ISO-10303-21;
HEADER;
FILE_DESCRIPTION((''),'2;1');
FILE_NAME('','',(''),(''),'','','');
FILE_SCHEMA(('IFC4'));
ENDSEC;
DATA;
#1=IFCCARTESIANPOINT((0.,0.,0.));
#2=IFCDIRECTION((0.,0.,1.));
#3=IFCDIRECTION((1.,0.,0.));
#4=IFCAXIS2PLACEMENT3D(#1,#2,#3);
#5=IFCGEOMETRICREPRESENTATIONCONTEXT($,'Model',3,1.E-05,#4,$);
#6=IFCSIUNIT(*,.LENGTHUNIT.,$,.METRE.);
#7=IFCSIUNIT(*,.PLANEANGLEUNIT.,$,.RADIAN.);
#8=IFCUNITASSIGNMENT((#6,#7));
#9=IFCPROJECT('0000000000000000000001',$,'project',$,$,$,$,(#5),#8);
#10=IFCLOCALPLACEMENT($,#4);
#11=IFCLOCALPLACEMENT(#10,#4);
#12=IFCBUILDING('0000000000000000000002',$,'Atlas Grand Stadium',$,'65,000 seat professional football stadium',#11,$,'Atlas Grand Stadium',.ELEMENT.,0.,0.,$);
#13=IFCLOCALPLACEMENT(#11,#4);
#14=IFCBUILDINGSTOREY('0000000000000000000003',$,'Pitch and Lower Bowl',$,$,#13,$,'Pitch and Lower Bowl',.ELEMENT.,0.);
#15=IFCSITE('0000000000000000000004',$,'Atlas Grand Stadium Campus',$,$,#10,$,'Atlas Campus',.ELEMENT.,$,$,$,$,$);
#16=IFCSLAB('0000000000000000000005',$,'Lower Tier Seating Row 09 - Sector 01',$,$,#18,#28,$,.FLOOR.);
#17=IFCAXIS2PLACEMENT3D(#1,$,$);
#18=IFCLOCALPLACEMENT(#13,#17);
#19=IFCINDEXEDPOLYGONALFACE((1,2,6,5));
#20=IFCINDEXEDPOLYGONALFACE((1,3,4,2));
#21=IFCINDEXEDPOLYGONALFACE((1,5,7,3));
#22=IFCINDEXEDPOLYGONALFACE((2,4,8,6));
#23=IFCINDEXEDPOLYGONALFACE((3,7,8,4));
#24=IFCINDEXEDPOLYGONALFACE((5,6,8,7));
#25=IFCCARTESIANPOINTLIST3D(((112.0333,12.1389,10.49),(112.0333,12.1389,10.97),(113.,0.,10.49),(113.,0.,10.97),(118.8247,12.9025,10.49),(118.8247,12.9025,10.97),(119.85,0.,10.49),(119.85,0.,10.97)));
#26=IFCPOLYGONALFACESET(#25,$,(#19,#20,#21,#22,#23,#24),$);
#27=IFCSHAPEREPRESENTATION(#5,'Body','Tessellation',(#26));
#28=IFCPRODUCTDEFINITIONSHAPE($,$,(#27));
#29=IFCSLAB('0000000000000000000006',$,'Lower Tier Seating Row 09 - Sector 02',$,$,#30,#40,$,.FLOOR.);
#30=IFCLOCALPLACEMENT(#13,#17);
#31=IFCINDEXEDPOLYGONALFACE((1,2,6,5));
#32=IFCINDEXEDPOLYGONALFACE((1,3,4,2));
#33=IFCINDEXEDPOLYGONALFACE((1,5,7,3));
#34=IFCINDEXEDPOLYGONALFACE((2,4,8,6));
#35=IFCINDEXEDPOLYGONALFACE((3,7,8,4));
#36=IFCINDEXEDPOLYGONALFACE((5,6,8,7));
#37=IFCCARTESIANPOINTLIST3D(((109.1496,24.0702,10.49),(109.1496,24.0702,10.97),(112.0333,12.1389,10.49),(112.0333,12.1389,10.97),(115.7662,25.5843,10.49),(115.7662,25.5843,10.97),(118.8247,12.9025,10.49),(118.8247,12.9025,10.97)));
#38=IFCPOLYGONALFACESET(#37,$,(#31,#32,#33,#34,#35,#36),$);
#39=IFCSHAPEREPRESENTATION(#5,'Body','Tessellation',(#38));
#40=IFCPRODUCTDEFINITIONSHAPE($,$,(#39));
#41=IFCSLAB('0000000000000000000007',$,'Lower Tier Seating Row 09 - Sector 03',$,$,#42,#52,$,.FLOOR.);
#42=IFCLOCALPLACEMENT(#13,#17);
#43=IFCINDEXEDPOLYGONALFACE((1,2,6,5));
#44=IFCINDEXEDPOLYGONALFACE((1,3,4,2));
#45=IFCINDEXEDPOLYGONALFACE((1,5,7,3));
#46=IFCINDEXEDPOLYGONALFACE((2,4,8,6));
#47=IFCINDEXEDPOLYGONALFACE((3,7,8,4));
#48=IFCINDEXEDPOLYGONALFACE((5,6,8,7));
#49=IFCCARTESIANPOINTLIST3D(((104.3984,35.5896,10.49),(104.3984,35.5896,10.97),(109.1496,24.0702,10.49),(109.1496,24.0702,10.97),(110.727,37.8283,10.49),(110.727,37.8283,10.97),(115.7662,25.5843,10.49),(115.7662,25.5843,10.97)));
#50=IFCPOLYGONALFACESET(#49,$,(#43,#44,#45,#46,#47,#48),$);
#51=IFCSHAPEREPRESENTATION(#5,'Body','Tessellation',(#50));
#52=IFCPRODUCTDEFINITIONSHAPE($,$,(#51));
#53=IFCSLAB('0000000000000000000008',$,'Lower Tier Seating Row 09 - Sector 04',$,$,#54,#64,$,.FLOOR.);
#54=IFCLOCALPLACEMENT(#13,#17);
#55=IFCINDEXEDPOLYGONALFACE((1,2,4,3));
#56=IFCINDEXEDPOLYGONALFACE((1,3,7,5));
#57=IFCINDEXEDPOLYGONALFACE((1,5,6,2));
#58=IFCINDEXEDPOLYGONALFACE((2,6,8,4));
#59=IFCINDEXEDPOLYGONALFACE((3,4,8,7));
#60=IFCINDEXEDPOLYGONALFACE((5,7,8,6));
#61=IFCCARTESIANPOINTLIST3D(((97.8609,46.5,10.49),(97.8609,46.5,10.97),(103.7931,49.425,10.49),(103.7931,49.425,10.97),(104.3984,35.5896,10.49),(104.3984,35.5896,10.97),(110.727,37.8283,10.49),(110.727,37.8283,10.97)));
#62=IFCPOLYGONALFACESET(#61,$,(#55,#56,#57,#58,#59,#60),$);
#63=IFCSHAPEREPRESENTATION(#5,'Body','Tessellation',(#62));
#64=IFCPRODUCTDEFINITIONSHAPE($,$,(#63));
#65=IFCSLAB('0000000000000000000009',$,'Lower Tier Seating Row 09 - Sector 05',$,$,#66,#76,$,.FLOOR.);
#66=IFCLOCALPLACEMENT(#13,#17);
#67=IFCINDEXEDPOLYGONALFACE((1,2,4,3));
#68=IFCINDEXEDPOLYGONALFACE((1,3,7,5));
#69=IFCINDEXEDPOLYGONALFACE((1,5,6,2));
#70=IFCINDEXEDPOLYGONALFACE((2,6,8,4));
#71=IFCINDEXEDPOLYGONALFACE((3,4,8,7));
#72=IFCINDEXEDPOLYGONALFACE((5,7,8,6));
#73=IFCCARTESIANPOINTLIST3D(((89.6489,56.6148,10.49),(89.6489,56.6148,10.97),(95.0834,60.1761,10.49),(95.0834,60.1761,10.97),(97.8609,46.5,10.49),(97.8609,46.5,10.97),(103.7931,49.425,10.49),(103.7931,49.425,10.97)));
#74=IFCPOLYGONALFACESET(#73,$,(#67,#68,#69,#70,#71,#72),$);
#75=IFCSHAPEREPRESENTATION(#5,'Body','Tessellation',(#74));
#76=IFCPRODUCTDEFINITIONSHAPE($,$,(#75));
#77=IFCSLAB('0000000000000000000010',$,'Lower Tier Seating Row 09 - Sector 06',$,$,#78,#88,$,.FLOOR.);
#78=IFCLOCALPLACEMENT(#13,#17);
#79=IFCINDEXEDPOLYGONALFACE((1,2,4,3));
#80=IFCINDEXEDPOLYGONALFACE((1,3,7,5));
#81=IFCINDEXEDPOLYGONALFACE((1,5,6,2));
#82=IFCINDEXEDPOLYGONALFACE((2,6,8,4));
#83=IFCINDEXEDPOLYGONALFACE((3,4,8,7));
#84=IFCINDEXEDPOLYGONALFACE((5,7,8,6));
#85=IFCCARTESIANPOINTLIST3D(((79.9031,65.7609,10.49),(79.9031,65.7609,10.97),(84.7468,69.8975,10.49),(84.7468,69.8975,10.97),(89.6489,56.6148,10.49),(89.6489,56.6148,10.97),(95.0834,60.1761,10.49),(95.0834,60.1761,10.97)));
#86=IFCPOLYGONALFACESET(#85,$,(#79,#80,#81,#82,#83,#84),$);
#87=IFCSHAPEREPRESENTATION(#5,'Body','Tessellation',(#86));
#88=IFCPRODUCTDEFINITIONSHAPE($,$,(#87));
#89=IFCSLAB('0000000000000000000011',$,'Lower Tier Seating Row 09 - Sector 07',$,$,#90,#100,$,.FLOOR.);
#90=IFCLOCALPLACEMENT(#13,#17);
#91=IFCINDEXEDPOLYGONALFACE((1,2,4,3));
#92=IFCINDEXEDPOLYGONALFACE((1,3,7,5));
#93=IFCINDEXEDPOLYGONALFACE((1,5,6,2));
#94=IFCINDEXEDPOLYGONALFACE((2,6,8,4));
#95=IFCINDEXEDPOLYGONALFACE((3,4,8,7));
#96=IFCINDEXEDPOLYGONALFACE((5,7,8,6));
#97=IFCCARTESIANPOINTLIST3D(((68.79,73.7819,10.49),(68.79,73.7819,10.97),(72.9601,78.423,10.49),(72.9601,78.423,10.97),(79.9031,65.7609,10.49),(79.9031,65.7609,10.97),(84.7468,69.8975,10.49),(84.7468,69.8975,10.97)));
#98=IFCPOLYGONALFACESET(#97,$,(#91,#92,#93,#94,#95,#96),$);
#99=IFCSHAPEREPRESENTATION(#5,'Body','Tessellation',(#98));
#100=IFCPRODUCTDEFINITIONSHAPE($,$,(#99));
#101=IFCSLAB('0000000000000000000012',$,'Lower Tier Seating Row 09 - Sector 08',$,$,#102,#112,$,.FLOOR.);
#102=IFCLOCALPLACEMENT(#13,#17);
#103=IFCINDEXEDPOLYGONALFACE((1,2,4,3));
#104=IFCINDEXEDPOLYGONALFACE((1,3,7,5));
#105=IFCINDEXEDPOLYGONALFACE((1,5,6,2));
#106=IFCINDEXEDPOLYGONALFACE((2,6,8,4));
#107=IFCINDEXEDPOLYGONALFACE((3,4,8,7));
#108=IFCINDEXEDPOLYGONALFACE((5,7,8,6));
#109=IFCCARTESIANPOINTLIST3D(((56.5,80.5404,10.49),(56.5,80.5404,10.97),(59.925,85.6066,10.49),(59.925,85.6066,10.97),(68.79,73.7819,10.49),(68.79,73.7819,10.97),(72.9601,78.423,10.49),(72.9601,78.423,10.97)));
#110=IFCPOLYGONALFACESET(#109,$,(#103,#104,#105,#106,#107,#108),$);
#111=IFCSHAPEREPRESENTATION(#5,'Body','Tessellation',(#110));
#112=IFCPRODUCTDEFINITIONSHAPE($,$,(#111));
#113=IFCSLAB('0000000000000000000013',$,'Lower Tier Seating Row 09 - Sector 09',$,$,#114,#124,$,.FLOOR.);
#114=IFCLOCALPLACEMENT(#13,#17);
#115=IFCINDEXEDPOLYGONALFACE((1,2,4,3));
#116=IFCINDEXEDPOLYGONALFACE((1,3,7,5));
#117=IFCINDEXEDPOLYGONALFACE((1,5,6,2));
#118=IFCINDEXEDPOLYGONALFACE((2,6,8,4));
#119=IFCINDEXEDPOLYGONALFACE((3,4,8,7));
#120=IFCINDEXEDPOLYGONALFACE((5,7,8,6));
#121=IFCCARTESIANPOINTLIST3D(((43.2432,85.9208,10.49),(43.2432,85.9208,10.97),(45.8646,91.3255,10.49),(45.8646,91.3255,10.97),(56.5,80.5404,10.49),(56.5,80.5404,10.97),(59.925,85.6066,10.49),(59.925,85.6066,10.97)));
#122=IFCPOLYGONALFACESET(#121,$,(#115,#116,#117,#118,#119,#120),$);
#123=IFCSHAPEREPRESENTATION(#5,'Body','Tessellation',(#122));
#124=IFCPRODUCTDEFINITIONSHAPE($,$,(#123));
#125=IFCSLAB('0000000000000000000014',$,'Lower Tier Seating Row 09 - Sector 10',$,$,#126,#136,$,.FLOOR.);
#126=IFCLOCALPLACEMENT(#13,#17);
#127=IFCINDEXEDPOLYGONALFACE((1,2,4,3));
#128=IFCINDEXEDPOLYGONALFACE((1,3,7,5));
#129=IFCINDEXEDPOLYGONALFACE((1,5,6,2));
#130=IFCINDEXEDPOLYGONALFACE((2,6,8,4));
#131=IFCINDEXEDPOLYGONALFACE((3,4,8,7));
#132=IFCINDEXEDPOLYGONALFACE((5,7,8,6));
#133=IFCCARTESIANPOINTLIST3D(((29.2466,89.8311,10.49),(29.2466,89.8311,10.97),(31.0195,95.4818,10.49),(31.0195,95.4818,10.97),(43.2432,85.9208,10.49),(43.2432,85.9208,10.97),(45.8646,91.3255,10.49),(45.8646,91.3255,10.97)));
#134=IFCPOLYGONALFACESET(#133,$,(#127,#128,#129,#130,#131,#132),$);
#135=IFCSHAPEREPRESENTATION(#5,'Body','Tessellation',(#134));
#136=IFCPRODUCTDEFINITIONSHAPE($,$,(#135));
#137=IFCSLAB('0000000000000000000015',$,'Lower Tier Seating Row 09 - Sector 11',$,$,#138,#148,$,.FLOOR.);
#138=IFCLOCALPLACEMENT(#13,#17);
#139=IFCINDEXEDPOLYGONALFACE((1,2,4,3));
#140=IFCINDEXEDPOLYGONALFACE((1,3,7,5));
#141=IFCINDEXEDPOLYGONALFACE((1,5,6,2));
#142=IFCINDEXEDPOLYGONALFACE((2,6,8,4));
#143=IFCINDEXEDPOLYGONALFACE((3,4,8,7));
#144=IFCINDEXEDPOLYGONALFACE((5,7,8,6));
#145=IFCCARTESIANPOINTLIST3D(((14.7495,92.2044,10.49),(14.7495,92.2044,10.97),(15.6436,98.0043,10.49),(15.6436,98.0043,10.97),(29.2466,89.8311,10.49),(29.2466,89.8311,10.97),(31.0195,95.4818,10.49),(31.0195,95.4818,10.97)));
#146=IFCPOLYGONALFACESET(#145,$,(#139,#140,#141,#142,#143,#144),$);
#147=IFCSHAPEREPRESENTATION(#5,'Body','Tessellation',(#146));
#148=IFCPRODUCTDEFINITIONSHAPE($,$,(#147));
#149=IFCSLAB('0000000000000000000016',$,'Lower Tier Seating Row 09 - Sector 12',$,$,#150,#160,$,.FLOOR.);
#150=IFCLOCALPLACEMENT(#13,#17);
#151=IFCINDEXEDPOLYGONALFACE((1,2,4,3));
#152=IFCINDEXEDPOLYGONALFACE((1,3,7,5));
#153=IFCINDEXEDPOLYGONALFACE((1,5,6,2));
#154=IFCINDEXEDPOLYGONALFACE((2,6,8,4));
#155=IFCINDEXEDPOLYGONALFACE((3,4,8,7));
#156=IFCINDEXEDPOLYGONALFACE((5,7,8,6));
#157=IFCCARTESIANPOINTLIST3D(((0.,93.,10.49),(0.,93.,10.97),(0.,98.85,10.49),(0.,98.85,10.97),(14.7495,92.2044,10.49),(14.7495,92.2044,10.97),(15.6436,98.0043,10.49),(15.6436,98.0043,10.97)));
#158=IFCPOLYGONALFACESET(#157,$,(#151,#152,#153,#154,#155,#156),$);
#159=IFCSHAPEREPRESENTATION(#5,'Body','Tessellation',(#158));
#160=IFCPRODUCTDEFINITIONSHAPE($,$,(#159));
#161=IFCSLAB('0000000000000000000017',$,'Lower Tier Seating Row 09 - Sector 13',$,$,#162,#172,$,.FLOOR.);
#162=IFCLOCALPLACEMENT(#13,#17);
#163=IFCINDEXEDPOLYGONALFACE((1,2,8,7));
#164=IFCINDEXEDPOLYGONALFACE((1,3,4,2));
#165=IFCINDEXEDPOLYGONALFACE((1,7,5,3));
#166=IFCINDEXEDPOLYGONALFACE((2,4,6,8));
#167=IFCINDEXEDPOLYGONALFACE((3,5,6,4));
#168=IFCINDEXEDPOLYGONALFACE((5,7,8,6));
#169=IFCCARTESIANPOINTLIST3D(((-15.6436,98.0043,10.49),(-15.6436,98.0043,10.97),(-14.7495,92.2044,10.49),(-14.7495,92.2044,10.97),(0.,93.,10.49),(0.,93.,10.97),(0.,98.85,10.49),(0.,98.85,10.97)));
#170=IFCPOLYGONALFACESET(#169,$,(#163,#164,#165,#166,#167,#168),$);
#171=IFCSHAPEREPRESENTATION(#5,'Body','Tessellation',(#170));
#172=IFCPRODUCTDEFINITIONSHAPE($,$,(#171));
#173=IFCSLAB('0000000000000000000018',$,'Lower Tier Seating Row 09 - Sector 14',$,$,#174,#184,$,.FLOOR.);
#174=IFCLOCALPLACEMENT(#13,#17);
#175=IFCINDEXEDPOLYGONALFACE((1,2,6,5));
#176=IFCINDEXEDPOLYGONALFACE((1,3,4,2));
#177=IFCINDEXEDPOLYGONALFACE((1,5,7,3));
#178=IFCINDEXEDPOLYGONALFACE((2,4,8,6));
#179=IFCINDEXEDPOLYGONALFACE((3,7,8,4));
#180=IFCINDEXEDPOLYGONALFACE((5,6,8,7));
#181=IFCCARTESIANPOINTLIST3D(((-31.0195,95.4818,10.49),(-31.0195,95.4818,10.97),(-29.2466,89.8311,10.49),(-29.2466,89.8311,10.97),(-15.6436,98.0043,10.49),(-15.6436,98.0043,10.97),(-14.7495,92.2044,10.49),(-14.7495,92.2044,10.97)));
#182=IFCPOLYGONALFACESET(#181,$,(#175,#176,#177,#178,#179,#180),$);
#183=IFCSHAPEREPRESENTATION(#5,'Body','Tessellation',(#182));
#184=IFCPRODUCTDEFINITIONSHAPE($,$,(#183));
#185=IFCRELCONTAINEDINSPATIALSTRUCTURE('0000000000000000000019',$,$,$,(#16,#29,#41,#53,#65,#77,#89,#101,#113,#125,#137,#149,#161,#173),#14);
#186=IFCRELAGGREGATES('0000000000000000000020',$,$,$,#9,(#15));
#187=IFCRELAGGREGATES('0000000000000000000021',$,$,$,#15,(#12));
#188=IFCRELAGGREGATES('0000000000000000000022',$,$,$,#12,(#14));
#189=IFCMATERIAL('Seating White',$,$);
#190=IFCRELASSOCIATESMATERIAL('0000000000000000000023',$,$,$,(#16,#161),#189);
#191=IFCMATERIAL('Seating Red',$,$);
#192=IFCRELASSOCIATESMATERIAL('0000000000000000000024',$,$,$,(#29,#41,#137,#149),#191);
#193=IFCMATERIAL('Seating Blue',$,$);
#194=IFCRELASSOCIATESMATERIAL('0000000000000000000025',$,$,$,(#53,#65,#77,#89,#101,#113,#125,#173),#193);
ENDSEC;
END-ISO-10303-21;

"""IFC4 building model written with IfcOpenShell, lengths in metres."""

from ifc_helpers import new_model, si_unit, frame, origin_with_axes, place, context, project, spatial, polyline, outline, extrude, material, element, save


model = new_model("IFC4")

# Units and contexts
model_context = context("Model", 3, precision=1e-05, world=origin_with_axes())
ifc_project = project(units=[si_unit("LENGTHUNIT", "METRE"), si_unit("PLANEANGLEUNIT", "RADIAN")], contexts=[model_context])

# Site, building, storey
site_placement = place(None, origin_with_axes())
site = spatial("IfcSite", under=ifc_project, at=site_placement, Name="Atlas Grand Stadium Campus", LongName="Atlas Campus", CompositionType="ELEMENT")
building_placement = place(site_placement, origin_with_axes())
building = spatial("IfcBuilding", under=site, at=building_placement, Name="Atlas Grand Stadium", ObjectType="65,000 seat professional football stadium", LongName="Atlas Grand Stadium", CompositionType="ELEMENT", ElevationOfRefHeight=0.0, ElevationOfTerrain=0.0)
storey_placement = place(building_placement, origin_with_axes())
storey = spatial("IfcBuildingStorey", under=building, at=storey_placement, Name="Pitch and Lower Bowl", LongName="Pitch and Lower Bowl", CompositionType="ELEMENT", Elevation=0.0)

# Slabs
ifc_material_1 = material(Name="Seating White")
slab_1_placement = place(storey_placement, frame((0.0, 0.0, 10.49), z_axis=(0.0, 0.0, 1.0), x_axis=(1.0, 0.0, 0.0)))
element("IfcSlab", 1, at=slab_1_placement, inside=storey, material=ifc_material_1, Name="Lower Tier Seating Row 09 - Sector 01", PredefinedType="FLOOR", context=model_context, shape_type="SweptSolid", body=[
    extrude(outline(polyline([(119.85, 0.0), (118.8247, 12.9025), (112.0333, 12.1389), (113.0, 0.0), (119.85, 0.0)])), origin_with_axes(), (0.0, 0.0, 1.0), 0.48),
])
ifc_material_2 = material(Name="Seating Red")
slab_2_placement = place(storey_placement, frame((0.0, 0.0, 10.49), z_axis=(0.0, 0.0, 1.0), x_axis=(1.0, 0.0, 0.0)))
element("IfcSlab", 2, at=slab_2_placement, inside=storey, material=ifc_material_2, Name="Lower Tier Seating Row 09 - Sector 02", PredefinedType="FLOOR", context=model_context, shape_type="SweptSolid", body=[
    extrude(outline(polyline([(118.8247, 12.9025), (115.7662, 25.5843), (109.1496, 24.0702), (112.0333, 12.1389), (118.8247, 12.9025)])), origin_with_axes(), (0.0, 0.0, 1.0), 0.48),
])
slab_3_placement = place(storey_placement, frame((0.0, 0.0, 10.49), z_axis=(0.0, 0.0, 1.0), x_axis=(1.0, 0.0, 0.0)))
element("IfcSlab", 3, at=slab_3_placement, inside=storey, material=ifc_material_2, Name="Lower Tier Seating Row 09 - Sector 03", PredefinedType="FLOOR", context=model_context, shape_type="SweptSolid", body=[
    extrude(outline(polyline([(115.7662, 25.5843), (110.727, 37.8283), (104.3984, 35.5896), (109.1496, 24.0702), (115.7662, 25.5843)])), origin_with_axes(), (0.0, 0.0, 1.0), 0.48),
])
ifc_material_3 = material(Name="Seating Blue")
slab_4_placement = place(storey_placement, frame((0.0, 0.0, 10.49), z_axis=(0.0, 0.0, 1.0), x_axis=(1.0, 0.0, 0.0)))
element("IfcSlab", 4, at=slab_4_placement, inside=storey, material=ifc_material_3, Name="Lower Tier Seating Row 09 - Sector 04", PredefinedType="FLOOR", context=model_context, shape_type="SweptSolid", body=[
    extrude(outline(polyline([(110.727, 37.8283), (103.7931, 49.425), (97.8609, 46.5), (104.3984, 35.5896), (110.727, 37.8283)])), origin_with_axes(), (0.0, 0.0, 1.0), 0.48),
])
slab_5_placement = place(storey_placement, frame((0.0, 0.0, 10.49), z_axis=(0.0, 0.0, 1.0), x_axis=(1.0, 0.0, 0.0)))
element("IfcSlab", 5, at=slab_5_placement, inside=storey, material=ifc_material_3, Name="Lower Tier Seating Row 09 - Sector 05", PredefinedType="FLOOR", context=model_context, shape_type="SweptSolid", body=[
    extrude(outline(polyline([(103.7931, 49.425), (95.0834, 60.1761), (89.6489, 56.6148), (97.8609, 46.5), (103.7931, 49.425)])), origin_with_axes(), (0.0, 0.0, 1.0), 0.48),
])
slab_6_placement = place(storey_placement, frame((0.0, 0.0, 10.49), z_axis=(0.0, 0.0, 1.0), x_axis=(1.0, 0.0, 0.0)))
element("IfcSlab", 6, at=slab_6_placement, inside=storey, material=ifc_material_3, Name="Lower Tier Seating Row 09 - Sector 06", PredefinedType="FLOOR", context=model_context, shape_type="SweptSolid", body=[
    extrude(outline(polyline([(95.0834, 60.1761), (84.7468, 69.8975), (79.9031, 65.7609), (89.6489, 56.6148), (95.0834, 60.1761)])), origin_with_axes(), (0.0, 0.0, 1.0), 0.48),
])
slab_7_placement = place(storey_placement, frame((0.0, 0.0, 10.49), z_axis=(0.0, 0.0, 1.0), x_axis=(1.0, 0.0, 0.0)))
element("IfcSlab", 7, at=slab_7_placement, inside=storey, material=ifc_material_3, Name="Lower Tier Seating Row 09 - Sector 07", PredefinedType="FLOOR", context=model_context, shape_type="SweptSolid", body=[
    extrude(outline(polyline([(84.7468, 69.8975), (72.9601, 78.423), (68.79, 73.7819), (79.9031, 65.7609), (84.7468, 69.8975)])), origin_with_axes(), (0.0, 0.0, 1.0), 0.48),
])
slab_8_placement = place(storey_placement, frame((0.0, 0.0, 10.49), z_axis=(0.0, 0.0, 1.0), x_axis=(1.0, 0.0, 0.0)))
element("IfcSlab", 8, at=slab_8_placement, inside=storey, material=ifc_material_3, Name="Lower Tier Seating Row 09 - Sector 08", PredefinedType="FLOOR", context=model_context, shape_type="SweptSolid", body=[
    extrude(outline(polyline([(72.9601, 78.423), (59.925, 85.6066), (56.5, 80.5404), (68.79, 73.7819), (72.9601, 78.423)])), origin_with_axes(), (0.0, 0.0, 1.0), 0.48),
])
slab_9_placement = place(storey_placement, frame((0.0, 0.0, 10.49), z_axis=(0.0, 0.0, 1.0), x_axis=(1.0, 0.0, 0.0)))
element("IfcSlab", 9, at=slab_9_placement, inside=storey, material=ifc_material_3, Name="Lower Tier Seating Row 09 - Sector 09", PredefinedType="FLOOR", context=model_context, shape_type="SweptSolid", body=[
    extrude(outline(polyline([(59.925, 85.6066), (45.8646, 91.3255), (43.2432, 85.9208), (56.5, 80.5404), (59.925, 85.6066)])), origin_with_axes(), (0.0, 0.0, 1.0), 0.48),
])
slab_10_placement = place(storey_placement, frame((0.0, 0.0, 10.49), z_axis=(0.0, 0.0, 1.0), x_axis=(1.0, 0.0, 0.0)))
element("IfcSlab", 10, at=slab_10_placement, inside=storey, material=ifc_material_3, Name="Lower Tier Seating Row 09 - Sector 10", PredefinedType="FLOOR", context=model_context, shape_type="SweptSolid", body=[
    extrude(outline(polyline([(45.8646, 91.3255), (31.0195, 95.4818), (29.2465, 89.8311), (43.2432, 85.9208), (45.8646, 91.3255)])), origin_with_axes(), (0.0, 0.0, 1.0), 0.48),
])
slab_11_placement = place(storey_placement, frame((0.0, 0.0, 10.49), z_axis=(0.0, 0.0, 1.0), x_axis=(1.0, 0.0, 0.0)))
element("IfcSlab", 11, at=slab_11_placement, inside=storey, material=ifc_material_2, Name="Lower Tier Seating Row 09 - Sector 11", PredefinedType="FLOOR", context=model_context, shape_type="SweptSolid", body=[
    extrude(outline(polyline([(31.0195, 95.4818), (15.6436, 98.0043), (14.7495, 92.2044), (29.2465, 89.8311), (31.0195, 95.4818)])), origin_with_axes(), (0.0, 0.0, 1.0), 0.48),
])
slab_12_placement = place(storey_placement, frame((0.0, 0.0, 10.49), z_axis=(0.0, 0.0, 1.0), x_axis=(1.0, 0.0, 0.0)))
element("IfcSlab", 12, at=slab_12_placement, inside=storey, material=ifc_material_2, Name="Lower Tier Seating Row 09 - Sector 12", PredefinedType="FLOOR", context=model_context, shape_type="SweptSolid", body=[
    extrude(outline(polyline([(15.6436, 98.0043), (0.0, 98.85), (0.0, 93.0), (14.7495, 92.2044), (15.6436, 98.0043)])), origin_with_axes(), (0.0, 0.0, 1.0), 0.48),
])
slab_13_placement = place(storey_placement, frame((0.0, 0.0, 10.49), z_axis=(0.0, 0.0, 1.0), x_axis=(1.0, 0.0, 0.0)))
element("IfcSlab", 13, at=slab_13_placement, inside=storey, material=ifc_material_1, Name="Lower Tier Seating Row 09 - Sector 13", PredefinedType="FLOOR", context=model_context, shape_type="SweptSolid", body=[
    extrude(outline(polyline([(0.0, 98.85), (-15.6436, 98.0043), (-14.7495, 92.2044), (0.0, 93.0), (0.0, 98.85)])), origin_with_axes(), (0.0, 0.0, 1.0), 0.48),
])
slab_14_placement = place(storey_placement, frame((0.0, 0.0, 10.49), z_axis=(0.0, 0.0, 1.0), x_axis=(1.0, 0.0, 0.0)))
element("IfcSlab", 14, at=slab_14_placement, inside=storey, material=ifc_material_3, Name="Lower Tier Seating Row 09 - Sector 14", PredefinedType="FLOOR", context=model_context, shape_type="SweptSolid", body=[
    extrude(outline(polyline([(-15.6436, 98.0043), (-31.0195, 95.4818), (-29.2465, 89.8311), (-14.7495, 92.2044), (-15.6436, 98.0043)])), origin_with_axes(), (0.0, 0.0, 1.0), 0.48),
])

save(model, "model.ifc")
